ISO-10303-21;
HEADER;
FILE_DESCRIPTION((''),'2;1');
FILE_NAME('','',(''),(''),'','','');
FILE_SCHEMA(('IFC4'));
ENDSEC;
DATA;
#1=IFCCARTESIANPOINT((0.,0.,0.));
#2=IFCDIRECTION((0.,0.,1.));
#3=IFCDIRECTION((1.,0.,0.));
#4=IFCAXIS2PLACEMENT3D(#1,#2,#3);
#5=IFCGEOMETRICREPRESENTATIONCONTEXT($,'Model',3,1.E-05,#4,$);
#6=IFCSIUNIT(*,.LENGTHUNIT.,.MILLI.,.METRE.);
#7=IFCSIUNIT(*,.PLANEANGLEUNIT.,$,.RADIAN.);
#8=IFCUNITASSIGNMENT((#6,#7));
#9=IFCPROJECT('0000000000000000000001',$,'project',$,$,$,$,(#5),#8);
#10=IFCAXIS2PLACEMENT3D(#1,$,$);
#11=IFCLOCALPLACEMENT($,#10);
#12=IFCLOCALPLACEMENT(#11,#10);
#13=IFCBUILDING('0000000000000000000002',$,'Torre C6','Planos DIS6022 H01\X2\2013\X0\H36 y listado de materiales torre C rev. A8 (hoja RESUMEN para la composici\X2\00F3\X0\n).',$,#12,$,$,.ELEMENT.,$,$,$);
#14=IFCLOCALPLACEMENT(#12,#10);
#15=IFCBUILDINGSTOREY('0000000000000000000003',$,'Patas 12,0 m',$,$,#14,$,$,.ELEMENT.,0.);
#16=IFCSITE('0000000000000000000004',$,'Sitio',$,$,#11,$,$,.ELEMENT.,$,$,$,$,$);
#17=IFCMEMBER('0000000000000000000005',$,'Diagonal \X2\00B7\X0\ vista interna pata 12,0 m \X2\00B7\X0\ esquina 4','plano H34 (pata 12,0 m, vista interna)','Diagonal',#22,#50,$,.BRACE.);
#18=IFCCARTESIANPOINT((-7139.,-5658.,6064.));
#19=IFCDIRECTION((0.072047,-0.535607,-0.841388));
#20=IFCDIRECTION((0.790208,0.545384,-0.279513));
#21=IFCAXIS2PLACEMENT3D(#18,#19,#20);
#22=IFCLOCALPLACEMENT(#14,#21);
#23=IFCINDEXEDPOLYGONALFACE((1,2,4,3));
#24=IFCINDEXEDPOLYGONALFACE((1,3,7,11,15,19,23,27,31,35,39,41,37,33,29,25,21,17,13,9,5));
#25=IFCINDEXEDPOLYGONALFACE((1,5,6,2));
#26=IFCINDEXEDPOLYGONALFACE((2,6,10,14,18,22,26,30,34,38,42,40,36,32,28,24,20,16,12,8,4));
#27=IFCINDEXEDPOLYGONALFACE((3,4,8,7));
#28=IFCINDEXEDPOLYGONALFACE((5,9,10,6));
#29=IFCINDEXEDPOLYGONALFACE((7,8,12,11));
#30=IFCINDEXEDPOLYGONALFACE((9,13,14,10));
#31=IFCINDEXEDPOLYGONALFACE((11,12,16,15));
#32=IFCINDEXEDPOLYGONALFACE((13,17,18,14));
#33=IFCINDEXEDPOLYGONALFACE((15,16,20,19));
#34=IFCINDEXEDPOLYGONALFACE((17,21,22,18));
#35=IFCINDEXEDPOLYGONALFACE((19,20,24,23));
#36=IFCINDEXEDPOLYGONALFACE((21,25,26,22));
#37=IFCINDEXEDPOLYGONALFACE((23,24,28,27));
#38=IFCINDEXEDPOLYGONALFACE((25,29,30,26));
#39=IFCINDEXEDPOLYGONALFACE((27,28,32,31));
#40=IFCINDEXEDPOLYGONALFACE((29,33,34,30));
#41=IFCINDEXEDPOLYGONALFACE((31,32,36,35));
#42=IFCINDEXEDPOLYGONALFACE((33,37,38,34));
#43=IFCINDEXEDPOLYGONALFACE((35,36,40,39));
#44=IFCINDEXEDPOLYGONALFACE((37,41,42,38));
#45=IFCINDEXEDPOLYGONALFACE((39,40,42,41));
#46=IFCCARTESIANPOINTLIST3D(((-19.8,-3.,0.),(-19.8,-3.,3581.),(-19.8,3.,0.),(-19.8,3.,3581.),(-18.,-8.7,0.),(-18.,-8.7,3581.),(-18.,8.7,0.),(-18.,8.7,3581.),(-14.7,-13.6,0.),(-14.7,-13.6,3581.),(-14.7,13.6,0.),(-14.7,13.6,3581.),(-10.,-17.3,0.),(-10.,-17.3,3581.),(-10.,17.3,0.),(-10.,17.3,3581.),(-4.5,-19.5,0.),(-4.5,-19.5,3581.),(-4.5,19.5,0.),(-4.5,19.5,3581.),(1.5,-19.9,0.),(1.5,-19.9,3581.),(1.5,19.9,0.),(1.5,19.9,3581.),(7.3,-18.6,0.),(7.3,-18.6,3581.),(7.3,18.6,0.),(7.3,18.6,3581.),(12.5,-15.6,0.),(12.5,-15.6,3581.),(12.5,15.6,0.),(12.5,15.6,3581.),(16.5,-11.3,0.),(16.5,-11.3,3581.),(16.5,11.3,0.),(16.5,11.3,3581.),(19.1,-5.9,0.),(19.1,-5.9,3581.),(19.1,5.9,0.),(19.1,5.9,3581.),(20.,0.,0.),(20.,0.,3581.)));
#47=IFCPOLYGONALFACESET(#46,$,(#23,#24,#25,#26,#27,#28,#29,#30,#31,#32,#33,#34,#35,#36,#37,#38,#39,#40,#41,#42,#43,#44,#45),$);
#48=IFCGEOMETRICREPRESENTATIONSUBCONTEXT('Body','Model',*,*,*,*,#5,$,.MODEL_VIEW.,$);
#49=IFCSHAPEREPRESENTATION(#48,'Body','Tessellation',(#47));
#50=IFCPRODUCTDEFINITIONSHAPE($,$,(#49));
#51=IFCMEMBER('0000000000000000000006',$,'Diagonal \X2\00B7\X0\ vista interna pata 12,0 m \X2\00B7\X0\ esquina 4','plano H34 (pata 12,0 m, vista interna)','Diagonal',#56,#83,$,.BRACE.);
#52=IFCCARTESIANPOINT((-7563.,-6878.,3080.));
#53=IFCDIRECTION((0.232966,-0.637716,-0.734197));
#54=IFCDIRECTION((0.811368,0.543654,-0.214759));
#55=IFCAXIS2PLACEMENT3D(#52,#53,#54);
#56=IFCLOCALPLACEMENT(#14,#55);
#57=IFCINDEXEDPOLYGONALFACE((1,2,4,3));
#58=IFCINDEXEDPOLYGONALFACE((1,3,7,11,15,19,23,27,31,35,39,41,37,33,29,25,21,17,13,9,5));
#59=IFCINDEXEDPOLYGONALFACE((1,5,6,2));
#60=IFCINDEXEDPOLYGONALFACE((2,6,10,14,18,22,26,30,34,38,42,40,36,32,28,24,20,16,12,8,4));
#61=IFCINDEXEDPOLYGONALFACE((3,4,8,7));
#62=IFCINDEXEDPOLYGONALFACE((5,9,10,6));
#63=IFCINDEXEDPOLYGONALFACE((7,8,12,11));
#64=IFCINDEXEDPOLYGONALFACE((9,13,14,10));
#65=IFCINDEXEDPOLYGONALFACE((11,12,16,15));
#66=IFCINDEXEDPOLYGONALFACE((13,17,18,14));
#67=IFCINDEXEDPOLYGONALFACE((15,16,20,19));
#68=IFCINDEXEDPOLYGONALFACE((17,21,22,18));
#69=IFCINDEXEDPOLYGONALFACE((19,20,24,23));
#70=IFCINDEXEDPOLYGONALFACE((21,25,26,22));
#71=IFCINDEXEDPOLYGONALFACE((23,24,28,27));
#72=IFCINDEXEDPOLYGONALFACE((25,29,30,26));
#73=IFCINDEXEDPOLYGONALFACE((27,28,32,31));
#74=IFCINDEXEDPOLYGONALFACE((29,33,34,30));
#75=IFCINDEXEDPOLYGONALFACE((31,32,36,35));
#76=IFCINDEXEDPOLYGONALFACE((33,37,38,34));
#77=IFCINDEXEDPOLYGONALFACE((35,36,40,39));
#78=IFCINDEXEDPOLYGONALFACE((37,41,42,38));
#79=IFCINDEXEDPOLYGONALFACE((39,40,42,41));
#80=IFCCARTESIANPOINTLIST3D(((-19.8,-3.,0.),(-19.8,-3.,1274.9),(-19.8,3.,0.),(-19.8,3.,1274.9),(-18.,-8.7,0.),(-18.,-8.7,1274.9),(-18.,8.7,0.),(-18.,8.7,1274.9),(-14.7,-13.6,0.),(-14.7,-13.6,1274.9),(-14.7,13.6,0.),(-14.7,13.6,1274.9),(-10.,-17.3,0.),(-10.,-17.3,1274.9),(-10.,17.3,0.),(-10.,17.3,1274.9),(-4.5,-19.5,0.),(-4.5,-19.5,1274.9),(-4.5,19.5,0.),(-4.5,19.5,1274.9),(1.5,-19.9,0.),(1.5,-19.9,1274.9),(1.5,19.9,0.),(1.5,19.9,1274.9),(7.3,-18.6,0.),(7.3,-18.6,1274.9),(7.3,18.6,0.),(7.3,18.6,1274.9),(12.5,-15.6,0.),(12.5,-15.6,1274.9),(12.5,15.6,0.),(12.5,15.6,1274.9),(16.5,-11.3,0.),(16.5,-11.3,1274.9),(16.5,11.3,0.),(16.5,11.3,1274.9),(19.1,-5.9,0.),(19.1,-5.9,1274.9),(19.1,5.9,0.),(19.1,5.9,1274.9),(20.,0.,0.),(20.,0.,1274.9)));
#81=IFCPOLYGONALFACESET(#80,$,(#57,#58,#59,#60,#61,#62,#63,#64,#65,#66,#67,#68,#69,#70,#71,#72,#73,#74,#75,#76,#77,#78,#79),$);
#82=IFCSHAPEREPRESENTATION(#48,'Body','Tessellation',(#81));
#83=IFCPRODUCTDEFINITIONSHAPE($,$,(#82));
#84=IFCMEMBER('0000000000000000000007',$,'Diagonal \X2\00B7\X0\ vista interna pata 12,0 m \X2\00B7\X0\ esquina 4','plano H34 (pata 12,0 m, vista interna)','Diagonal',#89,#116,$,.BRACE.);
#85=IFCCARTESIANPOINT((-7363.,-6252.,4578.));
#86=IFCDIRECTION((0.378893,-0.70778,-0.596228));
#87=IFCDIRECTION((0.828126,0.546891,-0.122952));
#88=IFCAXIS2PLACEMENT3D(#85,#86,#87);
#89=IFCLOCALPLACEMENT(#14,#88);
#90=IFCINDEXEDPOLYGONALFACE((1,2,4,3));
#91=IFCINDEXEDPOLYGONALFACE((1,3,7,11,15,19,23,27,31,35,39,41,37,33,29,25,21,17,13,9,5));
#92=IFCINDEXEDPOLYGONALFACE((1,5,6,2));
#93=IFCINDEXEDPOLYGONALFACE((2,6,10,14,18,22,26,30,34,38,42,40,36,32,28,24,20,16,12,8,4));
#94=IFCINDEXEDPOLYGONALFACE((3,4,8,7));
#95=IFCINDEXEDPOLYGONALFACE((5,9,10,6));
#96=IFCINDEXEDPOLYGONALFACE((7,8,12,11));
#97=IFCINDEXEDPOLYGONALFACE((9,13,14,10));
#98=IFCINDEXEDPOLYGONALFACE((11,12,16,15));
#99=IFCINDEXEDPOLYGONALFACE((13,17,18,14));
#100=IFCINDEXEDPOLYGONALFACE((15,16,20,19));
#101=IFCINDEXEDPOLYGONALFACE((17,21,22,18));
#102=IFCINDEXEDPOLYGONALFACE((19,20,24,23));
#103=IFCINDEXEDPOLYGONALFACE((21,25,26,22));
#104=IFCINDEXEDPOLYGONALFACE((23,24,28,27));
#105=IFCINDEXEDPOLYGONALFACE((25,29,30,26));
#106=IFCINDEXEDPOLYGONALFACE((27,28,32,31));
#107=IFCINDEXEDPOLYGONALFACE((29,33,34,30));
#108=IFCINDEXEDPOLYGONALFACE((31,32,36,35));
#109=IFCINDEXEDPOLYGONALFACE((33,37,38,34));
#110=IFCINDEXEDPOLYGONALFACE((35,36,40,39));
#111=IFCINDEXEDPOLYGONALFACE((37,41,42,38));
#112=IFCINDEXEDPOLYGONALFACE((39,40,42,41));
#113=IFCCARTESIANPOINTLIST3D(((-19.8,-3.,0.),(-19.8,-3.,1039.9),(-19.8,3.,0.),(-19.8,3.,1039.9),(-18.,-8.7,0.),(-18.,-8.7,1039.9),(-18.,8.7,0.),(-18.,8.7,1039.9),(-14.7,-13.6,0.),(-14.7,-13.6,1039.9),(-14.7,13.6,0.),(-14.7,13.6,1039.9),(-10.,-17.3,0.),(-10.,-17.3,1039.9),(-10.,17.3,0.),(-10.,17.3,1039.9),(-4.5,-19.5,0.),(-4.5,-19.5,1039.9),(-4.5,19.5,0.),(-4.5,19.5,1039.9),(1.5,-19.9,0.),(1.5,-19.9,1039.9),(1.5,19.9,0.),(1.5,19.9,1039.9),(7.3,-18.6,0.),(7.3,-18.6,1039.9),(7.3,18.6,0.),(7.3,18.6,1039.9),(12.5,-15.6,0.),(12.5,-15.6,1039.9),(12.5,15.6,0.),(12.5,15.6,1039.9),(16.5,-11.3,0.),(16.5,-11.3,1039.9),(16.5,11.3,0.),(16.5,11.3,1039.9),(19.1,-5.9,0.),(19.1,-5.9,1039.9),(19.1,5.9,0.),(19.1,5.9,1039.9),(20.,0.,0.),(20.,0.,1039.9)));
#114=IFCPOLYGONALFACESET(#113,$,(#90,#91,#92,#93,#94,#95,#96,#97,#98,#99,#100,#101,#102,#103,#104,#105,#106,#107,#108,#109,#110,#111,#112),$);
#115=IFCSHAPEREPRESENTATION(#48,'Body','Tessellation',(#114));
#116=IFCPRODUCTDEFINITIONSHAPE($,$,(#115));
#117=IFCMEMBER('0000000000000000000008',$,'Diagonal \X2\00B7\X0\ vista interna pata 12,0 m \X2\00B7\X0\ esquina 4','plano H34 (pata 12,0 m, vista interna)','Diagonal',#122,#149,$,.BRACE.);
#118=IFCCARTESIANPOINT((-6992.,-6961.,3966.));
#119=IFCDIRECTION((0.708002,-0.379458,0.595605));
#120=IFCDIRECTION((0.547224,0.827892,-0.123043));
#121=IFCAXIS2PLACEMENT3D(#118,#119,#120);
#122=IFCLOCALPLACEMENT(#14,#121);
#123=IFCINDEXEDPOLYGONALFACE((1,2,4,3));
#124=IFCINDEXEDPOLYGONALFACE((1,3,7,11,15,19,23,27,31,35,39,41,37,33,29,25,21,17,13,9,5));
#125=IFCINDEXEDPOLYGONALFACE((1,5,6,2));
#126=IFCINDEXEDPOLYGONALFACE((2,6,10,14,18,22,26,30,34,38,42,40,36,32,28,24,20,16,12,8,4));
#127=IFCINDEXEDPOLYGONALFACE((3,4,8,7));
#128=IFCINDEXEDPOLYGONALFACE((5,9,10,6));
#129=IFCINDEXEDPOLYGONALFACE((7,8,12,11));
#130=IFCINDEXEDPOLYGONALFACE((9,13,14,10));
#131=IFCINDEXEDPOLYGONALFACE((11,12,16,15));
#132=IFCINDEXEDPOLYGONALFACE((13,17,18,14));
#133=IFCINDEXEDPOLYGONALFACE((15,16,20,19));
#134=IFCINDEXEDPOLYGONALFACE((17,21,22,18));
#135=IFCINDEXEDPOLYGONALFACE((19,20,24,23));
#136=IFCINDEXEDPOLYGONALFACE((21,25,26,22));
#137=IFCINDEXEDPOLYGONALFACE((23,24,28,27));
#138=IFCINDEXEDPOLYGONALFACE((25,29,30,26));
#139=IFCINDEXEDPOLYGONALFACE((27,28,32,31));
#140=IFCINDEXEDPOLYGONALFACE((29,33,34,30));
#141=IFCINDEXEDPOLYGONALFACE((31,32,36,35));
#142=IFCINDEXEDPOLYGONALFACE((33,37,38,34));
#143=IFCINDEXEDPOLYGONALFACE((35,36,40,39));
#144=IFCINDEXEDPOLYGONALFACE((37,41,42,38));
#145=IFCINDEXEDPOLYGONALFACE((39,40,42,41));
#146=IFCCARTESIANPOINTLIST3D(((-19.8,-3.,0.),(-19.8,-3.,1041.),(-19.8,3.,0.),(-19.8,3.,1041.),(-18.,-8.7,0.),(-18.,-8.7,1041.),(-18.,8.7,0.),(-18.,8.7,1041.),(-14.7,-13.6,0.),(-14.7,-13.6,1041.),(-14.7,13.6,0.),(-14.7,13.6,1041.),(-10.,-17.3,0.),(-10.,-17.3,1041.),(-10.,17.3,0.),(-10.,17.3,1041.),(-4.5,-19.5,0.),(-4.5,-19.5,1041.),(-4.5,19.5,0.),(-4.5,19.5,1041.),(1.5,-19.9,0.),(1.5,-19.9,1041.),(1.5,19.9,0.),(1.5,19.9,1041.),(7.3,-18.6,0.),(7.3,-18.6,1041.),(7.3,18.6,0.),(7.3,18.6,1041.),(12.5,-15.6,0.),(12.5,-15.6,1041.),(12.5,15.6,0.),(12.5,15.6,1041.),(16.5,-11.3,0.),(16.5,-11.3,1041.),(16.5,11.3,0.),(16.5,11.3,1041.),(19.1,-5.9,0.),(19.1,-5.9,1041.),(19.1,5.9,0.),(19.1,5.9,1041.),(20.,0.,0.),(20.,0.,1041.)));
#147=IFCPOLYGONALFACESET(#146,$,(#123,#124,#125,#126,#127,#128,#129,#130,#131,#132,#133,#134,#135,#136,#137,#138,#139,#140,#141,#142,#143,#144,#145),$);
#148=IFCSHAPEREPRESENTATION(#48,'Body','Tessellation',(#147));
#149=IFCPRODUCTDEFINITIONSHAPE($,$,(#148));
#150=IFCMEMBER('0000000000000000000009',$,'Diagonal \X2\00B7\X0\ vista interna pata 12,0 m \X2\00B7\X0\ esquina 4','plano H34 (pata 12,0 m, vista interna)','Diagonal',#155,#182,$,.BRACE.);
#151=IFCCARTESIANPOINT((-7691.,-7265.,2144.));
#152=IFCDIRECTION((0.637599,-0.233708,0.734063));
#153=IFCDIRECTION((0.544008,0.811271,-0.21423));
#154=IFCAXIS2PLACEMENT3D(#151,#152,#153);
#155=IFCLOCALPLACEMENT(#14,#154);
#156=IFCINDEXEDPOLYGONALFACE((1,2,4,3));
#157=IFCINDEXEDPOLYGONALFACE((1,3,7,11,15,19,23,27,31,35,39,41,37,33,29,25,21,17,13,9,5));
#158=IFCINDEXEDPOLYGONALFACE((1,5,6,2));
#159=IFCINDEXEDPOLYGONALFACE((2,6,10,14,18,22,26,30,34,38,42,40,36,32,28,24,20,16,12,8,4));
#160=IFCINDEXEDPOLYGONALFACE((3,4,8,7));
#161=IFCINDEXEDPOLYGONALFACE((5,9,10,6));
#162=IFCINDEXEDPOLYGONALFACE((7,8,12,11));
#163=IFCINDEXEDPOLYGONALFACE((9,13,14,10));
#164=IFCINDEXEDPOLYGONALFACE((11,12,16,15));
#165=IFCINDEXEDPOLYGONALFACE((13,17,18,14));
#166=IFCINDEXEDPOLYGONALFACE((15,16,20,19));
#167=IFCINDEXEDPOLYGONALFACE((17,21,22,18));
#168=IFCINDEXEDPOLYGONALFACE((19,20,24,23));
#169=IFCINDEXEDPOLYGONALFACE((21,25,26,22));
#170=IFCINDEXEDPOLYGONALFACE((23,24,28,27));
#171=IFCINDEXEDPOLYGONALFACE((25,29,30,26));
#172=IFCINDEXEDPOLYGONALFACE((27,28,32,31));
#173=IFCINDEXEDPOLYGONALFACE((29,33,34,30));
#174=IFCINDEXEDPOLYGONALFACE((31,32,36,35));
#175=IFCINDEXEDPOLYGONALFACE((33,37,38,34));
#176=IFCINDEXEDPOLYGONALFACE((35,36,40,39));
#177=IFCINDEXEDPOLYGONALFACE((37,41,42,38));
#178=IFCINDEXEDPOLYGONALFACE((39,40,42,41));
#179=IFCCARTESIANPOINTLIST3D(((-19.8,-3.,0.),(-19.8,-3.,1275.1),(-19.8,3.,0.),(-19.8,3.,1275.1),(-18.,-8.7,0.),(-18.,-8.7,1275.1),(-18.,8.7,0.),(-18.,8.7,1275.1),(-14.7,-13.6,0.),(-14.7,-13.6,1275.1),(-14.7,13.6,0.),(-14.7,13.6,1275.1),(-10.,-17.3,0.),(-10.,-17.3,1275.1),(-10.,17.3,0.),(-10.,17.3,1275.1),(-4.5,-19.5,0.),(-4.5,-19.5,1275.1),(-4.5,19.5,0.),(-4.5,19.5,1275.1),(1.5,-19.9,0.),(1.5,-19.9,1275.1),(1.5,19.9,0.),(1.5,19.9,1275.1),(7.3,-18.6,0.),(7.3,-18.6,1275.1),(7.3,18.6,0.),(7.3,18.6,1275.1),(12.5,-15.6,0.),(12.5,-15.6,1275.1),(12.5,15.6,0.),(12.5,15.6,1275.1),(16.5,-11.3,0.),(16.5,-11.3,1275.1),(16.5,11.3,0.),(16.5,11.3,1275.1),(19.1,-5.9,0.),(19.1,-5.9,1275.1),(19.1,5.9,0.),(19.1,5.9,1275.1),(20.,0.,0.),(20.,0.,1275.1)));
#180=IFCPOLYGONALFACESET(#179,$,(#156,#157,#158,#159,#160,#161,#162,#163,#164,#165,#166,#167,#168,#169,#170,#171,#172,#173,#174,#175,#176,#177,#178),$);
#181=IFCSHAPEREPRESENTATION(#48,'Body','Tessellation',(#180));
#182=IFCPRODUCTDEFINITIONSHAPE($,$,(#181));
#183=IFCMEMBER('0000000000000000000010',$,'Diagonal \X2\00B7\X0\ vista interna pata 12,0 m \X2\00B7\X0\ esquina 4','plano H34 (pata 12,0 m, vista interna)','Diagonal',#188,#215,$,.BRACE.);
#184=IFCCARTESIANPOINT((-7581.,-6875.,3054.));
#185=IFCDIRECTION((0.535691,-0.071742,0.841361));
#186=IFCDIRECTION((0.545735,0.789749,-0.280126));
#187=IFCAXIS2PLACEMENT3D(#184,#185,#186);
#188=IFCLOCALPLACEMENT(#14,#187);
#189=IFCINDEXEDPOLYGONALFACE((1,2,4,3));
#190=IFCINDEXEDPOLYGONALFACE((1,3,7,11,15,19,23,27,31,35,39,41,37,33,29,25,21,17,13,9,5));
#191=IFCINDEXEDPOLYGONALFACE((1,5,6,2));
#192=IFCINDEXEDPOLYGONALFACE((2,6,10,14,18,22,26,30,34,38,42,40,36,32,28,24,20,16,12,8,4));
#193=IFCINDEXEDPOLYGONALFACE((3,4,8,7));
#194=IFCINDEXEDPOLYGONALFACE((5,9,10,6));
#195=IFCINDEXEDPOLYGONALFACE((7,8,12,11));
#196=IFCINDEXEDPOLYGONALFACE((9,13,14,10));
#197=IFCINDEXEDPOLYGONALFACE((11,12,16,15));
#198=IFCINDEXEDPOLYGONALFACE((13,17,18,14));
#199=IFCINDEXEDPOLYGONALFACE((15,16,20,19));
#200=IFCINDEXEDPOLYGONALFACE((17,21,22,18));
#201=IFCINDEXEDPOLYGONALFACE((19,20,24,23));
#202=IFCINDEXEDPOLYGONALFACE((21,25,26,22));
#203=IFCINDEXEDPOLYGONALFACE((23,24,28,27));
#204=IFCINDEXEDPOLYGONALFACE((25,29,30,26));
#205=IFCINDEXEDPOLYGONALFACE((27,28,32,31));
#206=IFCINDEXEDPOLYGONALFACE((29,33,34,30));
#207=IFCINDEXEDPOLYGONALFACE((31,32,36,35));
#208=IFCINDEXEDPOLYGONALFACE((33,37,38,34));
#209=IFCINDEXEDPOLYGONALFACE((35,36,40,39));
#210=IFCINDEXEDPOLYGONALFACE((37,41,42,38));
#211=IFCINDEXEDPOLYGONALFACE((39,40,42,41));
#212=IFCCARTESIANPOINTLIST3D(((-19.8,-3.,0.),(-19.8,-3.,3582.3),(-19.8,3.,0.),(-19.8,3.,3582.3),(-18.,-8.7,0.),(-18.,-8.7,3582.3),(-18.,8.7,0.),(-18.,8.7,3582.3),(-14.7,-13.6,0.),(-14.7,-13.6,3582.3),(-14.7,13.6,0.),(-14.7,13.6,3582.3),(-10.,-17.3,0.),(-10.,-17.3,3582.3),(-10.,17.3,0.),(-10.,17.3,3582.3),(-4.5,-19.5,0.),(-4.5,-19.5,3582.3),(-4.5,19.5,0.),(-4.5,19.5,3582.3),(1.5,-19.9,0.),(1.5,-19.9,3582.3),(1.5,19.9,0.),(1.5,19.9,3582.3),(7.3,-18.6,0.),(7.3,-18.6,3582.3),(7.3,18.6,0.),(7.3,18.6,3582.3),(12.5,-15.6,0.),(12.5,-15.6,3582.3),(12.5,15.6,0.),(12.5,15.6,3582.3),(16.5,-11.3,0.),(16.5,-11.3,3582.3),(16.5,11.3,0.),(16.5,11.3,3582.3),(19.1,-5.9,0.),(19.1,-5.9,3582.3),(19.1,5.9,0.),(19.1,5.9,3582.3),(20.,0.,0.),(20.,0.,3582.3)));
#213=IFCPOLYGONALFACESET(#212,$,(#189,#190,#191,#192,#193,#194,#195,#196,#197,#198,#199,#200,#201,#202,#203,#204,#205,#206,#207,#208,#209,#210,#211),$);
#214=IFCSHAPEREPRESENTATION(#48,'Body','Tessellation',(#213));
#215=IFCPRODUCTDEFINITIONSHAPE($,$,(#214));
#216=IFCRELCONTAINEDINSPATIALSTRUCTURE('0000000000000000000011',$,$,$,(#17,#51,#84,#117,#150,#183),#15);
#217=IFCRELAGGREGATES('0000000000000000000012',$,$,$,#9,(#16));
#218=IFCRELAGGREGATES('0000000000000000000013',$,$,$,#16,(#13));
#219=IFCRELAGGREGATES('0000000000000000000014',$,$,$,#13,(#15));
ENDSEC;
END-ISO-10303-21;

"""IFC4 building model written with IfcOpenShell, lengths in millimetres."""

from ifc_helpers import new_model, si_unit, frame, origin, origin_with_axes, place, context, subcontext, project, spatial, circle, extrude, element, save


model = new_model("IFC4")

# Units and contexts
model_context = context("Model", 3, precision=1e-05, world=origin_with_axes())
body_context = subcontext(model_context, "Body", "Model", "MODEL_VIEW")
ifc_project = project(units=[si_unit("LENGTHUNIT", "METRE", prefix="MILLI"), si_unit("PLANEANGLEUNIT", "RADIAN")], contexts=[model_context])

# Site, building, storey
site_placement = place(None, origin())
site = spatial("IfcSite", under=ifc_project, at=site_placement, Name="Sitio", CompositionType="ELEMENT")
building_placement = place(site_placement, origin())
building = spatial("IfcBuilding", under=site, at=building_placement, Name="Torre C6", Description="Planos DIS6022 H01–H36 y listado de materiales torre C rev. A8 (hoja RESUMEN para la composición).", CompositionType="ELEMENT")
storey_placement = place(building_placement, origin())
storey = spatial("IfcBuildingStorey", under=building, at=storey_placement, Name="Patas 12,0 m", CompositionType="ELEMENT", Elevation=0.0)

# Members
member_1_placement = place(storey_placement, frame((-7139.0, -5658.0, 6064.0), z_axis=(0.072047, -0.535607, -0.841388), x_axis=(0.790208, 0.545384, -0.279513)))
element("IfcMember", 1, at=member_1_placement, inside=storey, Name="Diagonal · vista interna pata 12,0 m · esquina 4", Description="plano H34 (pata 12,0 m, vista interna)", ObjectType="Diagonal", PredefinedType="BRACE", context=body_context, shape_type="SweptSolid", body=[
    extrude(circle(Radius=20.0), None, (0.0, 0.0, 1.0), 3581.0),
])
member_2_placement = place(storey_placement, frame((-7563.0, -6878.0, 3080.0), z_axis=(0.232966, -0.637716, -0.734197), x_axis=(0.811368, 0.543654, -0.214759)))
element("IfcMember", 2, at=member_2_placement, inside=storey, Name="Diagonal · vista interna pata 12,0 m · esquina 4", Description="plano H34 (pata 12,0 m, vista interna)", ObjectType="Diagonal", PredefinedType="BRACE", context=body_context, shape_type="SweptSolid", body=[
    extrude(circle(Radius=20.0), None, (0.0, 0.0, 1.0), 1274.9),
])
member_3_placement = place(storey_placement, frame((-7363.0, -6252.0, 4578.0), z_axis=(0.378893, -0.70778, -0.596228), x_axis=(0.828126, 0.546891, -0.122952)))
element("IfcMember", 3, at=member_3_placement, inside=storey, Name="Diagonal · vista interna pata 12,0 m · esquina 4", Description="plano H34 (pata 12,0 m, vista interna)", ObjectType="Diagonal", PredefinedType="BRACE", context=body_context, shape_type="SweptSolid", body=[
    extrude(circle(Radius=20.0), None, (0.0, 0.0, 1.0), 1039.9),
])
member_4_placement = place(storey_placement, frame((-6992.0, -6961.0, 3966.0), z_axis=(0.708002, -0.379458, 0.595605), x_axis=(0.547224, 0.827892, -0.123043)))
element("IfcMember", 4, at=member_4_placement, inside=storey, Name="Diagonal · vista interna pata 12,0 m · esquina 4", Description="plano H34 (pata 12,0 m, vista interna)", ObjectType="Diagonal", PredefinedType="BRACE", context=body_context, shape_type="SweptSolid", body=[
    extrude(circle(Radius=20.0), None, (0.0, 0.0, 1.0), 1041.0),
])
member_5_placement = place(storey_placement, frame((-7691.0, -7265.0, 2144.0), z_axis=(0.637599, -0.233708, 0.734063), x_axis=(0.544008, 0.811271, -0.21423)))
element("IfcMember", 5, at=member_5_placement, inside=storey, Name="Diagonal · vista interna pata 12,0 m · esquina 4", Description="plano H34 (pata 12,0 m, vista interna)", ObjectType="Diagonal", PredefinedType="BRACE", context=body_context, shape_type="SweptSolid", body=[
    extrude(circle(Radius=20.0), None, (0.0, 0.0, 1.0), 1275.1),
])
member_6_placement = place(storey_placement, frame((-7581.0, -6875.0, 3054.0), z_axis=(0.535691, -0.071742, 0.841361), x_axis=(0.545735, 0.789749, -0.280126)))
element("IfcMember", 6, at=member_6_placement, inside=storey, Name="Diagonal · vista interna pata 12,0 m · esquina 4", Description="plano H34 (pata 12,0 m, vista interna)", ObjectType="Diagonal", PredefinedType="BRACE", context=body_context, shape_type="SweptSolid", body=[
    extrude(circle(Radius=20.0), None, (0.0, 0.0, 1.0), 3582.3),
])

save(model, "model.ifc")
